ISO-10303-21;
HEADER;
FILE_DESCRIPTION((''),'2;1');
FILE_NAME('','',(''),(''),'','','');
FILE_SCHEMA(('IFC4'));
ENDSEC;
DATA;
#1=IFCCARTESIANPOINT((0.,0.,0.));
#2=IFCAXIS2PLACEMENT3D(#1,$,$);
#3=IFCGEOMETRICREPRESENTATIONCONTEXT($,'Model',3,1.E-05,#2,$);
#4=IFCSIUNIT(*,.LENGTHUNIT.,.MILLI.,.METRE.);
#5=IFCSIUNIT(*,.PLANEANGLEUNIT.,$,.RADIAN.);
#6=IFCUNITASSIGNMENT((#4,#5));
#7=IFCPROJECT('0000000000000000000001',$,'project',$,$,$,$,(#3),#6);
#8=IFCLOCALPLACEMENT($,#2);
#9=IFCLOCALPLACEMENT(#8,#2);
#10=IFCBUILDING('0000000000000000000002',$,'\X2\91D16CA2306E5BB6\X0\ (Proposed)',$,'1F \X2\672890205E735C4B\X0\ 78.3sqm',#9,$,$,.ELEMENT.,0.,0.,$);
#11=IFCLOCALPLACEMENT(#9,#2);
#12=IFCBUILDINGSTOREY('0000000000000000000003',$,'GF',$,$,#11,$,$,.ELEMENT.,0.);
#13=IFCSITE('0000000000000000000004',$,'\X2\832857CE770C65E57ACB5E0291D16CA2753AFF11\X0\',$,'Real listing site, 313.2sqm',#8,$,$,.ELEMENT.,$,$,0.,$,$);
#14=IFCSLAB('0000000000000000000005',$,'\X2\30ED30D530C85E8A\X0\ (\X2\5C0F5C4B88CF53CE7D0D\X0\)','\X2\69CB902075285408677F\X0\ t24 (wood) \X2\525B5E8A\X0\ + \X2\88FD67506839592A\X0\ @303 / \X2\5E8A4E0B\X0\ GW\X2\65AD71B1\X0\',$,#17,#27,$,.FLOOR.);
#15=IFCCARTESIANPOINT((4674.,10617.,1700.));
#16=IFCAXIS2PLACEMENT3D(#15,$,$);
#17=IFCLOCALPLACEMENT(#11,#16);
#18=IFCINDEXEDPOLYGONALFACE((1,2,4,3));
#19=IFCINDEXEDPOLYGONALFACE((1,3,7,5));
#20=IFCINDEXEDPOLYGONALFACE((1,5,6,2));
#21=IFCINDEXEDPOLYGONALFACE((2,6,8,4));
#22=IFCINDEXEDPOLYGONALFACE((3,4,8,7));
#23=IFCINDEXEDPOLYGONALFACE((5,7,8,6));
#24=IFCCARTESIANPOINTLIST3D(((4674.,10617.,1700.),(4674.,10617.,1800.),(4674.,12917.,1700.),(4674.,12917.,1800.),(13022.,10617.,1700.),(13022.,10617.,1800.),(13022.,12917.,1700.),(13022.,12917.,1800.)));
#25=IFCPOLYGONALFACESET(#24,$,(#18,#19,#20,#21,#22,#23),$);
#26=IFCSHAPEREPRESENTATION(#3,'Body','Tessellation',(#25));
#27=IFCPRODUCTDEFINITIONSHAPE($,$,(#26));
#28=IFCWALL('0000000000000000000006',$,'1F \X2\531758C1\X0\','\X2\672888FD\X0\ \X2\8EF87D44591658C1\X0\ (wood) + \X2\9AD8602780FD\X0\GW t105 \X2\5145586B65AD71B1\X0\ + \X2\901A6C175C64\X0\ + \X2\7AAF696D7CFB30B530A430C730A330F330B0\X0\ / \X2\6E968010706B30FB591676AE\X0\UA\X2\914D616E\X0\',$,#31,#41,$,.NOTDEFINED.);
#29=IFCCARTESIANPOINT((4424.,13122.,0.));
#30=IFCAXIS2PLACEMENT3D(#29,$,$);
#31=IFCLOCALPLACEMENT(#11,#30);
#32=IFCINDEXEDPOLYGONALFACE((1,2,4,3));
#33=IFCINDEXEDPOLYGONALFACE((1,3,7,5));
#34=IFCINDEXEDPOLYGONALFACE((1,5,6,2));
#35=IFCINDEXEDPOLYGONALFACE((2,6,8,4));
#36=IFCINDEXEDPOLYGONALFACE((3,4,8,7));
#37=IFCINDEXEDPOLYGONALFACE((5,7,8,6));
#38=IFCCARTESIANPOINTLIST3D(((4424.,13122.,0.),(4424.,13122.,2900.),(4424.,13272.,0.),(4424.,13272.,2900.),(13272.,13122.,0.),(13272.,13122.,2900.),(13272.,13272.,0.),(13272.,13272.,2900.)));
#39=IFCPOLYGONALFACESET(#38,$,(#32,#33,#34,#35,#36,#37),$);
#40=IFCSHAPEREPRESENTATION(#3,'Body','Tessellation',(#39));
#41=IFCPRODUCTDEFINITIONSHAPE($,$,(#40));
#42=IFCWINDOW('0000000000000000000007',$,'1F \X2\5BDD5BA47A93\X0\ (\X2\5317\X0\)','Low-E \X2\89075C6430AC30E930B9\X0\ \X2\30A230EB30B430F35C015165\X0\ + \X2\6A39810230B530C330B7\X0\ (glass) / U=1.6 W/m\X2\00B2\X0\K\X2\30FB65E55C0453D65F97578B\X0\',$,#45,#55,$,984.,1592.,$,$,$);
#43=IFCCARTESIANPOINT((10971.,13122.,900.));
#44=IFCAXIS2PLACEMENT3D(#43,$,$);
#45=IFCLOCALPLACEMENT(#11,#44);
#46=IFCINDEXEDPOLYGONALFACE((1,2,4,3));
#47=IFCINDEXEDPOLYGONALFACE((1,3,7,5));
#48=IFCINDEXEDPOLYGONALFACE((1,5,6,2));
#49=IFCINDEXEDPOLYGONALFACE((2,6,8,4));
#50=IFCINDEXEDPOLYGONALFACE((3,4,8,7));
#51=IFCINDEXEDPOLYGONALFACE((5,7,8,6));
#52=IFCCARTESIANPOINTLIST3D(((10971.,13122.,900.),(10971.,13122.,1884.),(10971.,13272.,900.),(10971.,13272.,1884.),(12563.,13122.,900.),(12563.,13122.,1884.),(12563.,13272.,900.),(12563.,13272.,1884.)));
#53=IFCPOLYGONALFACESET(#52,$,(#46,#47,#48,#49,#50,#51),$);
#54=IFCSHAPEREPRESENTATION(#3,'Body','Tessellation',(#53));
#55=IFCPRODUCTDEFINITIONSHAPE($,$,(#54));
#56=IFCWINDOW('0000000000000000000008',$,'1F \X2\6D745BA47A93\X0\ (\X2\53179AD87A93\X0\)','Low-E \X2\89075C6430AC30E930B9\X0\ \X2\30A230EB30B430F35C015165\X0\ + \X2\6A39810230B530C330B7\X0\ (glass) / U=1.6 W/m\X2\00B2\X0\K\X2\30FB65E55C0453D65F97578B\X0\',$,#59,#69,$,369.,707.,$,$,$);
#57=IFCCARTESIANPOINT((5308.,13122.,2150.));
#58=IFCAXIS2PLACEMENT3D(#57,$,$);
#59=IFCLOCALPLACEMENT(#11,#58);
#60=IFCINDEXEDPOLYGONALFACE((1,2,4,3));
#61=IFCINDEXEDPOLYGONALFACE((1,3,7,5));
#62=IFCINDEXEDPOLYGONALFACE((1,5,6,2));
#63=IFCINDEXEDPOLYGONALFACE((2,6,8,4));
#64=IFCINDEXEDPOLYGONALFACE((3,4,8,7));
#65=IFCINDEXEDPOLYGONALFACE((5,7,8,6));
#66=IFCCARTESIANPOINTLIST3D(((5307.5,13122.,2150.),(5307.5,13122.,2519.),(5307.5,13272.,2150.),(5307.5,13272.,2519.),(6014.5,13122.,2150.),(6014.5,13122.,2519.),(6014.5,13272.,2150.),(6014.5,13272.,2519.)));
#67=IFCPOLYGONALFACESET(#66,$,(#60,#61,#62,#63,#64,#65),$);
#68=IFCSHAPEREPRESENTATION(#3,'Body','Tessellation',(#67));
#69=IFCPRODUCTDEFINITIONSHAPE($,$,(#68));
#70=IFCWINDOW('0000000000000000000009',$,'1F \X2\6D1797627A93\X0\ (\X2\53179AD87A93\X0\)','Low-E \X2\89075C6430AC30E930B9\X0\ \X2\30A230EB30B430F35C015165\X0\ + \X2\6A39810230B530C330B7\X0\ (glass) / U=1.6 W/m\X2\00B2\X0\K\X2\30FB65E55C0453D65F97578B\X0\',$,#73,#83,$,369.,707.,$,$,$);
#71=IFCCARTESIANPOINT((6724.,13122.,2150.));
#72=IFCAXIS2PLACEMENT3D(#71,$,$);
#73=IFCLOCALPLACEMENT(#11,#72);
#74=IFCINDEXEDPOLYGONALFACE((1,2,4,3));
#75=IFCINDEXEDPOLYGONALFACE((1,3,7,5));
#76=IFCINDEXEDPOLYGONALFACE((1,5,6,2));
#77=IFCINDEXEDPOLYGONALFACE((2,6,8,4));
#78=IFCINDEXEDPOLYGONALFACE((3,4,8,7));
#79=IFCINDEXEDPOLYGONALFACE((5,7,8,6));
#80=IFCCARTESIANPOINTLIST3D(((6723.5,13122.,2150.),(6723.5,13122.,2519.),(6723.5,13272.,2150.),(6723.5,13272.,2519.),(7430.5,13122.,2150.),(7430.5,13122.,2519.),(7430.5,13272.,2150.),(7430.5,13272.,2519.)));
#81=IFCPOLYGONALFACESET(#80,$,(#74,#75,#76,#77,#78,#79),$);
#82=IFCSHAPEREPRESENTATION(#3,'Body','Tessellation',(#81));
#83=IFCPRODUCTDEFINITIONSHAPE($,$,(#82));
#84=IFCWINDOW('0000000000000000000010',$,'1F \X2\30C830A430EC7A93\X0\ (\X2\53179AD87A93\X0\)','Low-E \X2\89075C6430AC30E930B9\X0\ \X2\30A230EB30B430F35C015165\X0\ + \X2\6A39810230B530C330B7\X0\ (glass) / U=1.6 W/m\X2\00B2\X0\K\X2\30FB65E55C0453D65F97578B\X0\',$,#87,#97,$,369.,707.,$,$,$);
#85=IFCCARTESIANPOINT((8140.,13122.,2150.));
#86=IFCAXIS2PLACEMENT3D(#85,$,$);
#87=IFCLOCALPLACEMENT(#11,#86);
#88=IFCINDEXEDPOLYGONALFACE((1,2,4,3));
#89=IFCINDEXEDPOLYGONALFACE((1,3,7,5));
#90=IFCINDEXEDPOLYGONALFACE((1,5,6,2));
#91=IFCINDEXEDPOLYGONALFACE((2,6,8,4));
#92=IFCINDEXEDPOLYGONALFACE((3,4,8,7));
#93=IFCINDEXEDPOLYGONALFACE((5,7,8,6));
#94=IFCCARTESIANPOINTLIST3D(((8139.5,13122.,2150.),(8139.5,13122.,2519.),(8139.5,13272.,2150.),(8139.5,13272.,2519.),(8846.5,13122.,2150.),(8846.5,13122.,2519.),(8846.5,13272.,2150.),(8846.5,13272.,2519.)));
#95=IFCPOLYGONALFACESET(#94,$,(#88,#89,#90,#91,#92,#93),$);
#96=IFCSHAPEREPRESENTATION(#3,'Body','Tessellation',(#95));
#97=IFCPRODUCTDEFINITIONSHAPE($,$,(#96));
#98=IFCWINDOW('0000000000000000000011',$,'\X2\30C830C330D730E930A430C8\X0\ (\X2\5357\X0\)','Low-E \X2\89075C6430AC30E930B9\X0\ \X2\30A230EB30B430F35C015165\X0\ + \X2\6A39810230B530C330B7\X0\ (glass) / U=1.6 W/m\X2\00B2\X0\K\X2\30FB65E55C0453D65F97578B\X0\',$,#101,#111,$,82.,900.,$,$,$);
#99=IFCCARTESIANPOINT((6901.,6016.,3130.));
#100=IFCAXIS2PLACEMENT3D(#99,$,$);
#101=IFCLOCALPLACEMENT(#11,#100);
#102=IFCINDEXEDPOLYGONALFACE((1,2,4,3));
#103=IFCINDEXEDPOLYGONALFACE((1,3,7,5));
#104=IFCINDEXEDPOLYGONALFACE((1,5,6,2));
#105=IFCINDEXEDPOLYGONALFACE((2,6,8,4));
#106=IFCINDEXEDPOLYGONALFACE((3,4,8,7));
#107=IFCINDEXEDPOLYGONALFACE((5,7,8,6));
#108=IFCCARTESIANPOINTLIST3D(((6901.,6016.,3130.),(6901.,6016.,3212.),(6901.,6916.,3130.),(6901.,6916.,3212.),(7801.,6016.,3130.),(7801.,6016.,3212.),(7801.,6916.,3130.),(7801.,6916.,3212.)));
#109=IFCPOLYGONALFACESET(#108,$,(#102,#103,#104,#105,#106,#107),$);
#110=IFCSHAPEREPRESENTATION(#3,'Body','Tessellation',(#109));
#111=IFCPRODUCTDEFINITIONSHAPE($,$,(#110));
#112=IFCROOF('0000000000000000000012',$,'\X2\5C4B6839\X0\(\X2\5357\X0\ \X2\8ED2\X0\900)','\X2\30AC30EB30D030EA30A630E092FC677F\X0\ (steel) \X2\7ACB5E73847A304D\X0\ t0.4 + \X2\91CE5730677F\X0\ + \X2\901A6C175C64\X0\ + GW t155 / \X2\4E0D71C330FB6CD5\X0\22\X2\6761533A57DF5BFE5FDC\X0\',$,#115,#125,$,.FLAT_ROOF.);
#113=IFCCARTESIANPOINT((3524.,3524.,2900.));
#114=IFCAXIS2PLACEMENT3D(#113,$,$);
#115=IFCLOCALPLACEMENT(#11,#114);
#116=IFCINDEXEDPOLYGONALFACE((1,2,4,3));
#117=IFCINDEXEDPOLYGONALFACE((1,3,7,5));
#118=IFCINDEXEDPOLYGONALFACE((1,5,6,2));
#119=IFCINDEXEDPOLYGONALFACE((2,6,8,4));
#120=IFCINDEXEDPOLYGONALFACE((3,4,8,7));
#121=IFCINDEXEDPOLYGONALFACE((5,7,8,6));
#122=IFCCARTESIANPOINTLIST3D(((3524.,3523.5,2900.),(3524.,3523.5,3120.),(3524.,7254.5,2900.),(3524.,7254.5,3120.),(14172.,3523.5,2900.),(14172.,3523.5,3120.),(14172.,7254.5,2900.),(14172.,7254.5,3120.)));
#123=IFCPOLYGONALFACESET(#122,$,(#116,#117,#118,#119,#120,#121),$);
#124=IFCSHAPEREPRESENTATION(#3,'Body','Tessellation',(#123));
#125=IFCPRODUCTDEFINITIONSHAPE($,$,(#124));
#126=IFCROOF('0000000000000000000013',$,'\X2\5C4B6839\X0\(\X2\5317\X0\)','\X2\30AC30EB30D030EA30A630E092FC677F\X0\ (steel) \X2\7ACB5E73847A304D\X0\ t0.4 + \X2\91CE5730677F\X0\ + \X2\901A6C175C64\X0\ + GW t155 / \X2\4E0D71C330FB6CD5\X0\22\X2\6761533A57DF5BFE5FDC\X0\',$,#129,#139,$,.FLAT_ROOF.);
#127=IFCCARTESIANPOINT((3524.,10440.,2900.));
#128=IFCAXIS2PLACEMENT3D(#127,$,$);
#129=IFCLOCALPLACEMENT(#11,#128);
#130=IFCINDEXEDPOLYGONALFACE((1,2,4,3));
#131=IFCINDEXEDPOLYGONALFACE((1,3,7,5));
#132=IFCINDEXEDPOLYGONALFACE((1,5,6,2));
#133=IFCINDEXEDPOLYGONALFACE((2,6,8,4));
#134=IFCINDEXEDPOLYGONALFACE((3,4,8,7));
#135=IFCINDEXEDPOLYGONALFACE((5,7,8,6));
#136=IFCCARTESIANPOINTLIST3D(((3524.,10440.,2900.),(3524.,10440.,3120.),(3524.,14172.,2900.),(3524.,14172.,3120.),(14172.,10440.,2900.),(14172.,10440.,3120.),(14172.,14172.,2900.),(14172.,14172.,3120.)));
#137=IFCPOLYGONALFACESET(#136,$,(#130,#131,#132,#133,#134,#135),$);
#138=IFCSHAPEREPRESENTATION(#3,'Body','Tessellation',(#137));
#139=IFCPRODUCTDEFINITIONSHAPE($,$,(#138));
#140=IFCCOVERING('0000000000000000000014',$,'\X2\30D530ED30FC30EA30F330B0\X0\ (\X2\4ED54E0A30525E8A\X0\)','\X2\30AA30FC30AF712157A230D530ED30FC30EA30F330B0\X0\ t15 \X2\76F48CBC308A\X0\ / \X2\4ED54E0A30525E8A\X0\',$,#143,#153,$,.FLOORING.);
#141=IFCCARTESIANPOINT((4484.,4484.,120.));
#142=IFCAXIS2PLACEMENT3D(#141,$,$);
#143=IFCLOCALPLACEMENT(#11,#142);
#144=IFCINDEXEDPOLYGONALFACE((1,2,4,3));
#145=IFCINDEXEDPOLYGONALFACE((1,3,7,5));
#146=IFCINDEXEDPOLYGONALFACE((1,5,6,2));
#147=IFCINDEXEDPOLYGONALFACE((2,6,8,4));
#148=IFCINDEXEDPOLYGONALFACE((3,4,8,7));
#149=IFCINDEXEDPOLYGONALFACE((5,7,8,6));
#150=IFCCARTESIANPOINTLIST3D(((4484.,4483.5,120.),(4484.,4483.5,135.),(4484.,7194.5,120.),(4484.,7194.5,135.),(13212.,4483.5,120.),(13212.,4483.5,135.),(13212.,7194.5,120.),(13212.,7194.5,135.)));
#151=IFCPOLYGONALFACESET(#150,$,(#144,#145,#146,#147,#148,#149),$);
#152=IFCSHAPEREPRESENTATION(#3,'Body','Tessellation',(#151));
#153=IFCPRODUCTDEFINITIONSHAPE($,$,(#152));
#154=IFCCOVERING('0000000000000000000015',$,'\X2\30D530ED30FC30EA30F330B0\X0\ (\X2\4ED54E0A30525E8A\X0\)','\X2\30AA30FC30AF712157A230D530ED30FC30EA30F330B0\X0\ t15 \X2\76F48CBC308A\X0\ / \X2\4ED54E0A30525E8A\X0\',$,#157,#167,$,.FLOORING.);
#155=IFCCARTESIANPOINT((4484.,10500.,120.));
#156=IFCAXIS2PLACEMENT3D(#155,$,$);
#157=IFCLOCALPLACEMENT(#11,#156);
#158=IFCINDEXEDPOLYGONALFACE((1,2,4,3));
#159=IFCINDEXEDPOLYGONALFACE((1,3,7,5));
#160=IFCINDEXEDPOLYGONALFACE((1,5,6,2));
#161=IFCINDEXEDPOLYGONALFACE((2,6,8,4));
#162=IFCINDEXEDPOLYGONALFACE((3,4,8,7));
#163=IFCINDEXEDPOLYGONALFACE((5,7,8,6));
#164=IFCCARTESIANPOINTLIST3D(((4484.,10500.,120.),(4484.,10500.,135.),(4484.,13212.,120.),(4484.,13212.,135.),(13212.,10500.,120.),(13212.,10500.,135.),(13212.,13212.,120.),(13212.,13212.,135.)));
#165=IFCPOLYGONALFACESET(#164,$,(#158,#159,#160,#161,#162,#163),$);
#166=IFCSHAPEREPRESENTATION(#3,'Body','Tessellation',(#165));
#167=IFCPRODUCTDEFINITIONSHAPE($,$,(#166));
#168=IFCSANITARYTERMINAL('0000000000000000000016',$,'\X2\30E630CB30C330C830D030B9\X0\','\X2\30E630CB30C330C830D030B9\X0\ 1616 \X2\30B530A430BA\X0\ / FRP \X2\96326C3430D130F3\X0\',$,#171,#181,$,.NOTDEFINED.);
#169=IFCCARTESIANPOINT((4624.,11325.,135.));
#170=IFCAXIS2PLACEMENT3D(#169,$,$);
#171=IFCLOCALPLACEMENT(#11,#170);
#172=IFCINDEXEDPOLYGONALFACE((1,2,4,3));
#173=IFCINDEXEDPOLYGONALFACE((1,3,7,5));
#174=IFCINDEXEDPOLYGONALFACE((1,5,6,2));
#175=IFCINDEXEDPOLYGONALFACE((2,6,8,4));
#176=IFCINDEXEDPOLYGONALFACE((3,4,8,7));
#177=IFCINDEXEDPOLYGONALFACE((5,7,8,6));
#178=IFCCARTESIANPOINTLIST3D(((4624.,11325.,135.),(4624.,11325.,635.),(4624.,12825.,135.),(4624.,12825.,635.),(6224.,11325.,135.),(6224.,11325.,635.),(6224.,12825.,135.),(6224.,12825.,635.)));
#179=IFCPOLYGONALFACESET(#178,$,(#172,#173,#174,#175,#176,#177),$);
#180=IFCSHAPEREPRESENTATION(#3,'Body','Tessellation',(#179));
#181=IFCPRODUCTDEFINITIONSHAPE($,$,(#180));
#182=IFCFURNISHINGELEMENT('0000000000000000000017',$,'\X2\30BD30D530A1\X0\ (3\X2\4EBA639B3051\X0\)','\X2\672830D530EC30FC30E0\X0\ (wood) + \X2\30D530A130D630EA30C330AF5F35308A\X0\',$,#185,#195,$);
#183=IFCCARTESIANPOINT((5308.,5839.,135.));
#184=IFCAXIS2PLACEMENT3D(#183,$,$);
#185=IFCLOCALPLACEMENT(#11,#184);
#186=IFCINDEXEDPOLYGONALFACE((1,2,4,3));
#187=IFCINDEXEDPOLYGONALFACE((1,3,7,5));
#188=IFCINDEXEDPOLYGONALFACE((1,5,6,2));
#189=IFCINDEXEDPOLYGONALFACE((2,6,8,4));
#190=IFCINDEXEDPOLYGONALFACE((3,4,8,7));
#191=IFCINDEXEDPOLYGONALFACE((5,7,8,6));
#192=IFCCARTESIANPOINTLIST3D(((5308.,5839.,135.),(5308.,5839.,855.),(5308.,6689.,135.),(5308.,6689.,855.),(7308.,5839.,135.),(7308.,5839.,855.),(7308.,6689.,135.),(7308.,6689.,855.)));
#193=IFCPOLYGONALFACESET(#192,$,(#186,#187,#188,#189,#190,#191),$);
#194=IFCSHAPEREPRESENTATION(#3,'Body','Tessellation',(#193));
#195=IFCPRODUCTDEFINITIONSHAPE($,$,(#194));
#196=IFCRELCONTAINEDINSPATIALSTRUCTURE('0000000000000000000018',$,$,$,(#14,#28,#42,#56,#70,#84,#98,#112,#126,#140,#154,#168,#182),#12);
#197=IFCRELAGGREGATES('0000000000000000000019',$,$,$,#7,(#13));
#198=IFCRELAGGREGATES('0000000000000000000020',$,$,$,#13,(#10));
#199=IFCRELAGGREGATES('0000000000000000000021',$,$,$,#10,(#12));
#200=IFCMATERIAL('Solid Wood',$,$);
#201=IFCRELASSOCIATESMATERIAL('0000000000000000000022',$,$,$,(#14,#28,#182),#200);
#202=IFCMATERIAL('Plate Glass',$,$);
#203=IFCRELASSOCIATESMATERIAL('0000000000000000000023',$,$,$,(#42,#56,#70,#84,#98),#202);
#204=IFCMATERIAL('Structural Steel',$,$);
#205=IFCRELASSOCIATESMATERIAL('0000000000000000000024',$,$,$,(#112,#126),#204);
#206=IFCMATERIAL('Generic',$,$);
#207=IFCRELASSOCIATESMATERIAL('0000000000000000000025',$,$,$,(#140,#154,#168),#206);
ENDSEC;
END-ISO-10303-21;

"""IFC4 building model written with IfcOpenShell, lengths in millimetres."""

from ifc_helpers import new_model, si_unit, frame, frame_2d, origin, place, context, project, spatial, rectangle, extrude, material, element, fill, save


model = new_model("IFC4")

# Units and contexts
model_context = context("Model", 3, precision=1e-05, world=origin())
ifc_project = project(units=[si_unit("LENGTHUNIT", "METRE", prefix="MILLI"), si_unit("PLANEANGLEUNIT", "RADIAN")], contexts=[model_context])

# Site, building, storey
site_placement = place(None, origin())
site = spatial("IfcSite", under=ifc_project, at=site_placement, Name="茨城県日立市金沢町１", ObjectType="Real listing site, 313.2sqm", CompositionType="ELEMENT", RefElevation=0.0)
building_placement = place(site_placement, origin())
building = spatial("IfcBuilding", under=site, at=building_placement, Name="金沢の家 (Proposed)", ObjectType="1F 木造平屋 78.3sqm", CompositionType="ELEMENT", ElevationOfRefHeight=0.0, ElevationOfTerrain=0.0)
storey_placement = place(building_placement, origin())
storey = spatial("IfcBuildingStorey", under=building, at=storey_placement, Name="GF", CompositionType="ELEMENT", Elevation=0.0)

# Slab
ifc_material_1 = material(Name="Solid Wood")
slab_1_placement = place(storey_placement, frame((4674.0, 10617.0, 1700.0)))
element("IfcSlab", 1, at=slab_1_placement, inside=storey, material=ifc_material_1, Name="ロフト床 (小屋裏収納)", Description="構造用合板 t24 (wood) 剛床 + 製材根太 @303 / 床下 GW断熱", PredefinedType="FLOOR", context=model_context, shape_type="SweptSolid", body=[
    extrude(rectangle(XDim=8348.0, YDim=2300.0, at=frame_2d((4174.0, 1150.0))), frame((4674.0, 10617.0, 1700.0)), (0.0, 0.0, 1.0), 100.0),
])

# Shared definitions
ifc_material_2 = material(Name="Plate Glass")

# Wall, openings, windows
wall_1_placement = place(storey_placement, frame((4424.0, 13122.0, 0.0)))
wall_1 = element("IfcWall", 2, at=wall_1_placement, inside=storey, material=ifc_material_1, Name="1F 北壁", Description="木製 軸組外壁 (wood) + 高性能GW t105 充填断熱 + 通気層 + 窯業系サイディング / 準耐火・外皮UA配慮", PredefinedType="NOTDEFINED", context=model_context, shape_type="SweptSolid", body=[
    extrude(rectangle(XDim=8848.0, YDim=150.0, at=frame_2d((4424.0, 75.0))), frame((4424.0, 13122.0, 0.0)), (0.0, 0.0, 1.0), 2900.0),
])
opening_1_placement = place(storey_placement, frame((10971.0, 13122.0, 900.0)))
opening_1 = element("IfcOpeningElement", 3, at=opening_1_placement, cuts=wall_1, PredefinedType="NOTDEFINED", context=model_context, shape_type="SweptSolid", body=[
    extrude(rectangle(XDim=1592.0, YDim=150.0, at=frame_2d((796.0, 75.0))), frame((10971.0, 13122.0, 900.0)), (0.0, 0.0, 1.0), 984.0),
])
opening_2_placement = place(storey_placement, frame((5308.0, 13122.0, 2150.0)))
opening_2 = element("IfcOpeningElement", 4, at=opening_2_placement, cuts=wall_1, PredefinedType="NOTDEFINED", context=model_context, shape_type="SweptSolid", body=[
    extrude(rectangle(XDim=707.0, YDim=150.0, at=frame_2d((353.0, 75.0))), frame((5308.0, 13122.0, 2150.0)), (0.0, 0.0, 1.0), 369.0),
])
opening_3_placement = place(storey_placement, frame((6724.0, 13122.0, 2150.0)))
opening_3 = element("IfcOpeningElement", 5, at=opening_3_placement, cuts=wall_1, PredefinedType="NOTDEFINED", context=model_context, shape_type="SweptSolid", body=[
    extrude(rectangle(XDim=707.0, YDim=150.0, at=frame_2d((353.0, 75.0))), frame((6724.0, 13122.0, 2150.0)), (0.0, 0.0, 1.0), 369.0),
])
opening_4_placement = place(storey_placement, frame((8140.0, 13122.0, 2150.0)))
opening_4 = element("IfcOpeningElement", 6, at=opening_4_placement, cuts=wall_1, PredefinedType="NOTDEFINED", context=model_context, shape_type="SweptSolid", body=[
    extrude(rectangle(XDim=707.0, YDim=150.0, at=frame_2d((353.0, 75.0))), frame((8140.0, 13122.0, 2150.0)), (0.0, 0.0, 1.0), 369.0),
])
window_1_placement = place(storey_placement, frame((10971.0, 13122.0, 900.0)))
window_1 = element("IfcWindow", 7, at=window_1_placement, inside=storey, material=ifc_material_2, Name="1F 寝室窓 (北)", Description="Low-E 複層ガラス アルゴン封入 + 樹脂サッシ (glass) / U=1.6 W/m²K・日射取得型", OverallHeight=984.0, OverallWidth=1592.0, context=model_context, shape_type="SweptSolid", body=[
    extrude(rectangle(XDim=1592.0, YDim=150.0, at=frame_2d((796.0, 75.0))), frame((10971.0, 13122.0, 900.0)), (0.0, 0.0, 1.0), 984.0),
])
fill(opening_1, window_1)
window_2_placement = place(storey_placement, frame((5308.0, 13122.0, 2150.0)))
window_2 = element("IfcWindow", 8, at=window_2_placement, inside=storey, material=ifc_material_2, Name="1F 浴室窓 (北高窓)", Description="Low-E 複層ガラス アルゴン封入 + 樹脂サッシ (glass) / U=1.6 W/m²K・日射取得型", OverallHeight=369.0, OverallWidth=707.0, context=model_context, shape_type="SweptSolid", body=[
    extrude(rectangle(XDim=707.0, YDim=150.0, at=frame_2d((353.0, 75.0))), frame((5308.0, 13122.0, 2150.0)), (0.0, 0.0, 1.0), 369.0),
])
fill(opening_2, window_2)
window_3_placement = place(storey_placement, frame((6724.0, 13122.0, 2150.0)))
window_3 = element("IfcWindow", 9, at=window_3_placement, inside=storey, material=ifc_material_2, Name="1F 洗面窓 (北高窓)", Description="Low-E 複層ガラス アルゴン封入 + 樹脂サッシ (glass) / U=1.6 W/m²K・日射取得型", OverallHeight=369.0, OverallWidth=707.0, context=model_context, shape_type="SweptSolid", body=[
    extrude(rectangle(XDim=707.0, YDim=150.0, at=frame_2d((353.0, 75.0))), frame((6724.0, 13122.0, 2150.0)), (0.0, 0.0, 1.0), 369.0),
])
fill(opening_3, window_3)
window_4_placement = place(storey_placement, frame((8140.0, 13122.0, 2150.0)))
window_4 = element("IfcWindow", 10, at=window_4_placement, inside=storey, material=ifc_material_2, Name="1F トイレ窓 (北高窓)", Description="Low-E 複層ガラス アルゴン封入 + 樹脂サッシ (glass) / U=1.6 W/m²K・日射取得型", OverallHeight=369.0, OverallWidth=707.0, context=model_context, shape_type="SweptSolid", body=[
    extrude(rectangle(XDim=707.0, YDim=150.0, at=frame_2d((353.0, 75.0))), frame((8140.0, 13122.0, 2150.0)), (0.0, 0.0, 1.0), 369.0),
])
fill(opening_4, window_4)

# Window
window_5_placement = place(storey_placement, frame((6901.0, 6016.0, 3130.0)))
element("IfcWindow", 11, at=window_5_placement, inside=storey, material=ifc_material_2, Name="トップライト (南)", Description="Low-E 複層ガラス アルゴン封入 + 樹脂サッシ (glass) / U=1.6 W/m²K・日射取得型", OverallHeight=82.0, OverallWidth=900.0, context=model_context, shape_type="SweptSolid", body=[
    extrude(rectangle(XDim=900.0, YDim=900.0, at=frame_2d((450.0, 450.0))), frame((6901.0, 6016.0, 3130.0)), (0.0, 0.0, 1.0), 82.0),
])

# Roofs
ifc_material_3 = material(Name="Structural Steel")
roof_1_placement = place(storey_placement, frame((3524.0, 3524.0, 2900.0)))
element("IfcRoof", 12, at=roof_1_placement, inside=storey, material=ifc_material_3, Name="屋根(南 軒900)", Description="ガルバリウム鋼板 (steel) 立平葺き t0.4 + 野地板 + 通気層 + GW t155 / 不燃・法22条区域対応", PredefinedType="FLAT_ROOF", context=model_context, shape_type="SweptSolid", body=[
    extrude(rectangle(XDim=10648.0, YDim=3731.0, at=frame_2d((5324.0, 1865.0))), frame((3524.0, 3524.0, 2900.0)), (0.0, 0.0, 1.0), 220.0),
])
roof_2_placement = place(storey_placement, frame((3524.0, 10440.0, 2900.0)))
element("IfcRoof", 13, at=roof_2_placement, inside=storey, material=ifc_material_3, Name="屋根(北)", Description="ガルバリウム鋼板 (steel) 立平葺き t0.4 + 野地板 + 通気層 + GW t155 / 不燃・法22条区域対応", PredefinedType="FLAT_ROOF", context=model_context, shape_type="SweptSolid", body=[
    extrude(rectangle(XDim=10648.0, YDim=3732.0, at=frame_2d((5324.0, 1866.0))), frame((3524.0, 10440.0, 2900.0)), (0.0, 0.0, 1.0), 220.0),
])

# Coverings
ifc_material_4 = material(Name="Generic")
covering_1_placement = place(storey_placement, frame((4484.0, 4484.0, 120.0)))
element("IfcCovering", 14, at=covering_1_placement, inside=storey, material=ifc_material_4, Name="フローリング (仕上げ床)", Description="オーク無垢フローリング t15 直貼り / 仕上げ床", PredefinedType="FLOORING", context=model_context, shape_type="SweptSolid", body=[
    extrude(rectangle(XDim=8728.0, YDim=2711.0, at=frame_2d((4364.0, 1355.0))), frame((4484.0, 4484.0, 120.0)), (0.0, 0.0, 1.0), 15.0),
])
covering_2_placement = place(storey_placement, frame((4484.0, 10500.0, 120.0)))
element("IfcCovering", 15, at=covering_2_placement, inside=storey, material=ifc_material_4, Name="フローリング (仕上げ床)", Description="オーク無垢フローリング t15 直貼り / 仕上げ床", PredefinedType="FLOORING", context=model_context, shape_type="SweptSolid", body=[
    extrude(rectangle(XDim=8728.0, YDim=2712.0, at=frame_2d((4364.0, 1356.0))), frame((4484.0, 10500.0, 120.0)), (0.0, 0.0, 1.0), 15.0),
])

# Sanitary terminal
sanitary_terminal_placement = place(storey_placement, frame((4624.0, 11325.0, 135.0)))
element("IfcSanitaryTerminal", 16, at=sanitary_terminal_placement, inside=storey, material=ifc_material_4, Name="ユニットバス", Description="ユニットバス 1616 サイズ / FRP 防水パン", PredefinedType="NOTDEFINED", context=model_context, shape_type="SweptSolid", body=[
    extrude(rectangle(XDim=1600.0, YDim=1500.0, at=frame_2d((800.0, 750.0))), frame((4624.0, 11325.0, 135.0)), (0.0, 0.0, 1.0), 500.0),
])

# Furnishing element
furnishing_1_placement = place(storey_placement, frame((5308.0, 5839.0, 135.0)))
element("IfcFurnishingElement", 17, at=furnishing_1_placement, inside=storey, material=ifc_material_1, Name="ソファ (3人掛け)", Description="木フレーム (wood) + ファブリック張り", context=model_context, shape_type="SweptSolid", body=[
    extrude(rectangle(XDim=2000.0, YDim=850.0, at=frame_2d((1000.0, 425.0))), frame((5308.0, 5839.0, 135.0)), (0.0, 0.0, 1.0), 720.0),
])

save(model, "model.ifc")
